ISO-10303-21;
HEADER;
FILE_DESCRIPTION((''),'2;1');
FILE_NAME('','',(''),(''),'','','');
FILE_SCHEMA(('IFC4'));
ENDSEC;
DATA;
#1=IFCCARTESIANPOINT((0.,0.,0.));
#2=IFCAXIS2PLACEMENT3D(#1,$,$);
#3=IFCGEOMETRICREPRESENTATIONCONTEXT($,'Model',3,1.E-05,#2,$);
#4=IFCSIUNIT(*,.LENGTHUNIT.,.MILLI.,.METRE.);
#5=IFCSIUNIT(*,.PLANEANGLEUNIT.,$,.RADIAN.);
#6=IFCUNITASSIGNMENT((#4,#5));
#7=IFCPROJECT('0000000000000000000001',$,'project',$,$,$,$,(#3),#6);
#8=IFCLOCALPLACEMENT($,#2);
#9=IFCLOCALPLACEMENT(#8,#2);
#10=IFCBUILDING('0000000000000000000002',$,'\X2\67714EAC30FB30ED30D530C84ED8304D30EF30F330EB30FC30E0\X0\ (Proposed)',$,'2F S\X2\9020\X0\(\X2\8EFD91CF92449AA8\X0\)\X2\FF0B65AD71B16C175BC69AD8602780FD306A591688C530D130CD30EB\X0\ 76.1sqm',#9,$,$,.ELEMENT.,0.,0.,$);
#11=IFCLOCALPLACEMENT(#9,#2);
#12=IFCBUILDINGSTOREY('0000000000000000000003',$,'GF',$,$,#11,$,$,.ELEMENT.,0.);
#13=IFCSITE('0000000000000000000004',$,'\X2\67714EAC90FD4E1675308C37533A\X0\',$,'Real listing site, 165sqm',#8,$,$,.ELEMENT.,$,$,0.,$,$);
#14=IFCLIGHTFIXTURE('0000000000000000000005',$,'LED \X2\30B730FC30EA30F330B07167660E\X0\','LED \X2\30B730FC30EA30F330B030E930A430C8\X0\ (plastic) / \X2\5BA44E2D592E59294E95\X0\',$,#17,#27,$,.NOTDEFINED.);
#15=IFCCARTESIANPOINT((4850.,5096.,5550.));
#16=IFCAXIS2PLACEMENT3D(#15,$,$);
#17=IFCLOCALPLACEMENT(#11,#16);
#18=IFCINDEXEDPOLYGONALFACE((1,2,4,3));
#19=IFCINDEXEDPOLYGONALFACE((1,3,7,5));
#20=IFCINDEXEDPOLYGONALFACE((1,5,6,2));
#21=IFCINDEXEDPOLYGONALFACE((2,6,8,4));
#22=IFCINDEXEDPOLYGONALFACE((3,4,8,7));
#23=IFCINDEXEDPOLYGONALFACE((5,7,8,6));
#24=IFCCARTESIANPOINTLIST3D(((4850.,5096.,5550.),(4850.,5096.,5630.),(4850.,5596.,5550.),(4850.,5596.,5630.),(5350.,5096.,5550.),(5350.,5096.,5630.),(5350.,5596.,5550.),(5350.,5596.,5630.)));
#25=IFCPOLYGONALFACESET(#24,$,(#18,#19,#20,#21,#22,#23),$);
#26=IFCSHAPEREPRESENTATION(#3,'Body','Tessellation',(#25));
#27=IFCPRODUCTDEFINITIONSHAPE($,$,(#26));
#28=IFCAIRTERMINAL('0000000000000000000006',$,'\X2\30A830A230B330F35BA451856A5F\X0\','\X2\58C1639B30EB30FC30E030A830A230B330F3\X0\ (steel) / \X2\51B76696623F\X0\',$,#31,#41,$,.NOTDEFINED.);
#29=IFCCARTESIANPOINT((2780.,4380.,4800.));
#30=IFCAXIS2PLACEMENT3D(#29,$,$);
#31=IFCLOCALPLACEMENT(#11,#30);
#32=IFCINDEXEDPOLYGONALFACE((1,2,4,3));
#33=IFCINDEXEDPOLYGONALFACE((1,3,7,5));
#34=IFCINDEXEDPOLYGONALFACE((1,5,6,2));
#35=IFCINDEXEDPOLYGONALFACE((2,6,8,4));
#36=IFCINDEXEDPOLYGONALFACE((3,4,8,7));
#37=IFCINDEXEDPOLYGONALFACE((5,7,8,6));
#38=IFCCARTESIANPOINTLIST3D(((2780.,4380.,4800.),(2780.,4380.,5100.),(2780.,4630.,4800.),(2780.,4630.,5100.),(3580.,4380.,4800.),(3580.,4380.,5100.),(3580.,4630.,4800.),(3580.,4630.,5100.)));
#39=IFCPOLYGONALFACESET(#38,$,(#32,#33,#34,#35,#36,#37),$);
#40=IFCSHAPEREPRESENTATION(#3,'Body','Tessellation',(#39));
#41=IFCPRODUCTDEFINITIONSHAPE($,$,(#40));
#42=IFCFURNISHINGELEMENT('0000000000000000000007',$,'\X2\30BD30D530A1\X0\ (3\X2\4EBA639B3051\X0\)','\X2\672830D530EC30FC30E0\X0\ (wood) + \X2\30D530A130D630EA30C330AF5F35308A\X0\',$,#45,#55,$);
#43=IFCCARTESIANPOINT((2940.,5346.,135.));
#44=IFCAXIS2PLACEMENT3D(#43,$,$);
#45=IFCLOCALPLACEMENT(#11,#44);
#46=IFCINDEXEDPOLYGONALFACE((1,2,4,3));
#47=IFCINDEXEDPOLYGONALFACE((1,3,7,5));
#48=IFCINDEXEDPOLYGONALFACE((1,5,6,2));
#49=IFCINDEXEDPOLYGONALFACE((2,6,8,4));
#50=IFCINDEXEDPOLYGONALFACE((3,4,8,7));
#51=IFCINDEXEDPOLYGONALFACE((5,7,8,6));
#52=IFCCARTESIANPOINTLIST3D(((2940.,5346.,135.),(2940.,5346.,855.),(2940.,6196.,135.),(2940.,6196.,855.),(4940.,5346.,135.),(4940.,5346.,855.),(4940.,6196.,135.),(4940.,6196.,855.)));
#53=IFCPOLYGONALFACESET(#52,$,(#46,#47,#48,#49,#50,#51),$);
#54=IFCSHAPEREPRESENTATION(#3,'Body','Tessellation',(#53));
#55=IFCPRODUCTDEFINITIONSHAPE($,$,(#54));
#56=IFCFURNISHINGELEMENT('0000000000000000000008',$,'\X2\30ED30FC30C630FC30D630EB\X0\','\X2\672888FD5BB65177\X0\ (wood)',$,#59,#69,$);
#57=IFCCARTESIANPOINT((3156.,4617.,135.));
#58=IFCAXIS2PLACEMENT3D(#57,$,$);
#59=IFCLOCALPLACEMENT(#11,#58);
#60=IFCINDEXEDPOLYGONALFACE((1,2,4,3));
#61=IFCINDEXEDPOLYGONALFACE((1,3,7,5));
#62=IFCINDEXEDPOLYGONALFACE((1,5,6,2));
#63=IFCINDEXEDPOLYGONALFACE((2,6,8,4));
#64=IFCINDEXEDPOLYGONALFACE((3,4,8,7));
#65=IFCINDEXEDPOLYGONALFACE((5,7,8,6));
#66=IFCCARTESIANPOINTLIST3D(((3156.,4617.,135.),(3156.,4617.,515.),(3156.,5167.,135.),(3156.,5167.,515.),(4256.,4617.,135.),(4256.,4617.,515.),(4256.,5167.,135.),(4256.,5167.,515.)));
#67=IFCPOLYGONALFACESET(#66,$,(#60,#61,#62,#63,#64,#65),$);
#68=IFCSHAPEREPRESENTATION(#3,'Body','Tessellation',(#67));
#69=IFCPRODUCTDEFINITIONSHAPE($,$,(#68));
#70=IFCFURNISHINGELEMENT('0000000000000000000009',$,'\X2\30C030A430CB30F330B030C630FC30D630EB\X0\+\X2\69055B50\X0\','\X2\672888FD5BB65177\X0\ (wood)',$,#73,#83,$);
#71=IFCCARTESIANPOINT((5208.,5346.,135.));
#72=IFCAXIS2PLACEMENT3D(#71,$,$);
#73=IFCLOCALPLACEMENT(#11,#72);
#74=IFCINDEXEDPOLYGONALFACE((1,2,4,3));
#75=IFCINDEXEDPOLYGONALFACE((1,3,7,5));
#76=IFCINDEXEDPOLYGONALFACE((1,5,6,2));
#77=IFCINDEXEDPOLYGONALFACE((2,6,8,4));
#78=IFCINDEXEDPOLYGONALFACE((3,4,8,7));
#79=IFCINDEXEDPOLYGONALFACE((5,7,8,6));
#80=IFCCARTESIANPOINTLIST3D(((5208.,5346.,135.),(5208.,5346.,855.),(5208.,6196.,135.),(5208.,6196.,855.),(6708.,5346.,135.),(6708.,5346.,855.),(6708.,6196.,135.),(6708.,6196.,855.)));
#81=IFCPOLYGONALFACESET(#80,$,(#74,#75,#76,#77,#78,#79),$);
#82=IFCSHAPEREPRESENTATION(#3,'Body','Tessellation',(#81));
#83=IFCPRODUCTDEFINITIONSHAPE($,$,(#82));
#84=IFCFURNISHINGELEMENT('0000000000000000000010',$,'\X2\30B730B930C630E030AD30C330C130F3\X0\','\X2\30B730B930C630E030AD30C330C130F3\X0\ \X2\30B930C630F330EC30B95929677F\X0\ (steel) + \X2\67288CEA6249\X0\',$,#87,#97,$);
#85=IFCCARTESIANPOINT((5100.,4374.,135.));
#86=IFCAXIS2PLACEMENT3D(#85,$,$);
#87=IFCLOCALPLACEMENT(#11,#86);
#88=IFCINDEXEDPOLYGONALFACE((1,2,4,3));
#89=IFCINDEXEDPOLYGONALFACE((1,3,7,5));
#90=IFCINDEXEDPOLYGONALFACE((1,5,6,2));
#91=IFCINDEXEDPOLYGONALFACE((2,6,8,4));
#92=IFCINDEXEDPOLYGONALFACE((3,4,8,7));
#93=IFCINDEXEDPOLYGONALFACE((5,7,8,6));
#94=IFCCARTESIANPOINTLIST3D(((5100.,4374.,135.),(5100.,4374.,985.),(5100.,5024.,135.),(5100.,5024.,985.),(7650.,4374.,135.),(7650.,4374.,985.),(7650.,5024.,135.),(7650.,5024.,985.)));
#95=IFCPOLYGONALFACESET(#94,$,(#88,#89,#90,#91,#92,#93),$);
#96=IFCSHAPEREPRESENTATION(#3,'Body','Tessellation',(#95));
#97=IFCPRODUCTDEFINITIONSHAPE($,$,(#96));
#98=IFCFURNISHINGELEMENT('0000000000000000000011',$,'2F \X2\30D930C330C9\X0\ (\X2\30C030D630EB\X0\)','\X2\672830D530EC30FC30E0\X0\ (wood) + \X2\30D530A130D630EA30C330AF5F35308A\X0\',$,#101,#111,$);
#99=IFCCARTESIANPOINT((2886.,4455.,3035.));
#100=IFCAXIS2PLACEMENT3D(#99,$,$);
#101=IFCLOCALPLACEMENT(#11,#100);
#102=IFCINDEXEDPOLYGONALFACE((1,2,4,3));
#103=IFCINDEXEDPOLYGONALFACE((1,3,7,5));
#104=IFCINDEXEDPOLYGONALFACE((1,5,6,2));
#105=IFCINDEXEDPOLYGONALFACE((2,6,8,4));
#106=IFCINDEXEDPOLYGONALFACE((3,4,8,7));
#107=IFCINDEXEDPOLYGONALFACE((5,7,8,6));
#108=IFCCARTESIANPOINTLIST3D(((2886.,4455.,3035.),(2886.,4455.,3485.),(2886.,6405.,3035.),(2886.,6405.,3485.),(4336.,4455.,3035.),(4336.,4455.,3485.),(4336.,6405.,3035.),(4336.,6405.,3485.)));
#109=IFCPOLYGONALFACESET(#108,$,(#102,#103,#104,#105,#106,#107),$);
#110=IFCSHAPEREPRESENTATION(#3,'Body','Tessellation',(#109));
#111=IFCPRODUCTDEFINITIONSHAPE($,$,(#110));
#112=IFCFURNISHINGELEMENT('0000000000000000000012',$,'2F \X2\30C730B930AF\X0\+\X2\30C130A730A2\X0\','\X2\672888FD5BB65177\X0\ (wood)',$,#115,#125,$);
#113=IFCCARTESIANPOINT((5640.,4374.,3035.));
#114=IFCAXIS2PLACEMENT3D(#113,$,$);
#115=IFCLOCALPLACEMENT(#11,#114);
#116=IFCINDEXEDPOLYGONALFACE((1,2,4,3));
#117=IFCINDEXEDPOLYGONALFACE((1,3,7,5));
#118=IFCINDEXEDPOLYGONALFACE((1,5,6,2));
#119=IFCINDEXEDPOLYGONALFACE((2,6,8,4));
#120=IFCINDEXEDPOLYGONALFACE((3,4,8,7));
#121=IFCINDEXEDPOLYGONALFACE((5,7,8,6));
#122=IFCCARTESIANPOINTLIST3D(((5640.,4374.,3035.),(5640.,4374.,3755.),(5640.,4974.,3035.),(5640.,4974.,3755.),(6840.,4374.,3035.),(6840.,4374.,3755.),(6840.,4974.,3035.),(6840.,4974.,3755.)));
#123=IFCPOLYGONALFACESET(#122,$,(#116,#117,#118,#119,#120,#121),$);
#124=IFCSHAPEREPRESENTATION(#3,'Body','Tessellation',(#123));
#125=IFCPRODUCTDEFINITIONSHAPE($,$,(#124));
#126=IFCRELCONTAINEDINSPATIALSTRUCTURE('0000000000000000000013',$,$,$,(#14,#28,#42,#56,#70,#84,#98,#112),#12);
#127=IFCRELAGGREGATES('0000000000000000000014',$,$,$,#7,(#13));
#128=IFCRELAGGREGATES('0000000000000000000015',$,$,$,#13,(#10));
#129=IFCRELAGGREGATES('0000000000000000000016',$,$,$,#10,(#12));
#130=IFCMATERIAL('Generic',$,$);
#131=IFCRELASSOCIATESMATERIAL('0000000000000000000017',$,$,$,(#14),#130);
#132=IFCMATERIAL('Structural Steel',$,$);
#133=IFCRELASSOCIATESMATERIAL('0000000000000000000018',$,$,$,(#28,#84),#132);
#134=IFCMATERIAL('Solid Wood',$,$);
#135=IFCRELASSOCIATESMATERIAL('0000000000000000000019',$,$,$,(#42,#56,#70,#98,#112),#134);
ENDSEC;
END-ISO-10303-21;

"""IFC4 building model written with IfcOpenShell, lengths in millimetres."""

from ifc_helpers import new_model, si_unit, frame, frame_2d, origin, place, context, project, spatial, rectangle, extrude, material, element, save


model = new_model("IFC4")

# Units and contexts
model_context = context("Model", 3, precision=1e-05, world=origin())
ifc_project = project(units=[si_unit("LENGTHUNIT", "METRE", prefix="MILLI"), si_unit("PLANEANGLEUNIT", "RADIAN")], contexts=[model_context])

# Site, building, storey
site_placement = place(None, origin())
site = spatial("IfcSite", under=ifc_project, at=site_placement, Name="東京都世田谷区", ObjectType="Real listing site, 165sqm", CompositionType="ELEMENT", RefElevation=0.0)
building_placement = place(site_placement, origin())
building = spatial("IfcBuilding", under=site, at=building_placement, Name="東京・ロフト付きワンルーム (Proposed)", ObjectType="2F S造(軽量鉄骨)＋断熱気密高性能な外装パネル 76.1sqm", CompositionType="ELEMENT", ElevationOfRefHeight=0.0, ElevationOfTerrain=0.0)
storey_placement = place(building_placement, origin())
storey = spatial("IfcBuildingStorey", under=building, at=storey_placement, Name="GF", CompositionType="ELEMENT", Elevation=0.0)

# Shared definitions
ifc_material_1 = material(Name="Solid Wood")

# Shared definitions
ifc_material_2 = material(Name="Generic")

# Shared definitions
ifc_material_3 = material(Name="Structural Steel")

# Light fixture
light_fixture_1_placement = place(storey_placement, frame((4850.0, 5096.0, 5550.0)))
element("IfcLightFixture", 1, at=light_fixture_1_placement, inside=storey, material=ifc_material_2, Name="LED シーリング照明", Description="LED シーリングライト (plastic) / 室中央天井", PredefinedType="NOTDEFINED", context=model_context, shape_type="SweptSolid", body=[
    extrude(rectangle(XDim=500.0, YDim=500.0, at=frame_2d((250.0, 250.0))), frame((4850.0, 5096.0, 5550.0)), (0.0, 0.0, 1.0), 80.0),
])

# Air terminal
air_terminal_placement = place(storey_placement, frame((2780.0, 4380.0, 4800.0)))
element("IfcAirTerminal", 2, at=air_terminal_placement, inside=storey, material=ifc_material_3, Name="エアコン室内機", Description="壁掛ルームエアコン (steel) / 冷暖房", PredefinedType="NOTDEFINED", context=model_context, shape_type="SweptSolid", body=[
    extrude(rectangle(XDim=800.0, YDim=250.0, at=frame_2d((400.0, 125.0))), frame((2780.0, 4380.0, 4800.0)), (0.0, 0.0, 1.0), 300.0),
])

# Furnishing elements
furnishing_1_placement = place(storey_placement, frame((2940.0, 5346.0, 135.0)))
element("IfcFurnishingElement", 3, at=furnishing_1_placement, inside=storey, material=ifc_material_1, Name="ソファ (3人掛け)", Description="木フレーム (wood) + ファブリック張り", context=model_context, shape_type="SweptSolid", body=[
    extrude(rectangle(XDim=2000.0, YDim=850.0, at=frame_2d((1000.0, 425.0))), frame((2940.0, 5346.0, 135.0)), (0.0, 0.0, 1.0), 720.0),
])
furnishing_2_placement = place(storey_placement, frame((3156.0, 4617.0, 135.0)))
element("IfcFurnishingElement", 4, at=furnishing_2_placement, inside=storey, material=ifc_material_1, Name="ローテーブル", Description="木製家具 (wood)", context=model_context, shape_type="SweptSolid", body=[
    extrude(rectangle(XDim=1100.0, YDim=550.0, at=frame_2d((550.0, 275.0))), frame((3156.0, 4617.0, 135.0)), (0.0, 0.0, 1.0), 380.0),
])
furnishing_3_placement = place(storey_placement, frame((5208.0, 5346.0, 135.0)))
element("IfcFurnishingElement", 5, at=furnishing_3_placement, inside=storey, material=ifc_material_1, Name="ダイニングテーブル+椅子", Description="木製家具 (wood)", context=model_context, shape_type="SweptSolid", body=[
    extrude(rectangle(XDim=1500.0, YDim=850.0, at=frame_2d((750.0, 425.0))), frame((5208.0, 5346.0, 135.0)), (0.0, 0.0, 1.0), 720.0),
])
furnishing_4_placement = place(storey_placement, frame((5100.0, 4374.0, 135.0)))
element("IfcFurnishingElement", 6, at=furnishing_4_placement, inside=storey, material=ifc_material_3, Name="システムキッチン", Description="システムキッチン ステンレス天板 (steel) + 木質扉", context=model_context, shape_type="SweptSolid", body=[
    extrude(rectangle(XDim=2550.0, YDim=650.0, at=frame_2d((1275.0, 325.0))), frame((5100.0, 4374.0, 135.0)), (0.0, 0.0, 1.0), 850.0),
])
furnishing_5_placement = place(storey_placement, frame((2886.0, 4455.0, 3035.0)))
element("IfcFurnishingElement", 7, at=furnishing_5_placement, inside=storey, material=ifc_material_1, Name="2F ベッド (ダブル)", Description="木フレーム (wood) + ファブリック張り", context=model_context, shape_type="SweptSolid", body=[
    extrude(rectangle(XDim=1450.0, YDim=1950.0, at=frame_2d((725.0, 975.0))), frame((2886.0, 4455.0, 3035.0)), (0.0, 0.0, 1.0), 450.0),
])
furnishing_6_placement = place(storey_placement, frame((5640.0, 4374.0, 3035.0)))
element("IfcFurnishingElement", 8, at=furnishing_6_placement, inside=storey, material=ifc_material_1, Name="2F デスク+チェア", Description="木製家具 (wood)", context=model_context, shape_type="SweptSolid", body=[
    extrude(rectangle(XDim=1200.0, YDim=600.0, at=frame_2d((600.0, 300.0))), frame((5640.0, 4374.0, 3035.0)), (0.0, 0.0, 1.0), 720.0),
])

save(model, "model.ifc")
